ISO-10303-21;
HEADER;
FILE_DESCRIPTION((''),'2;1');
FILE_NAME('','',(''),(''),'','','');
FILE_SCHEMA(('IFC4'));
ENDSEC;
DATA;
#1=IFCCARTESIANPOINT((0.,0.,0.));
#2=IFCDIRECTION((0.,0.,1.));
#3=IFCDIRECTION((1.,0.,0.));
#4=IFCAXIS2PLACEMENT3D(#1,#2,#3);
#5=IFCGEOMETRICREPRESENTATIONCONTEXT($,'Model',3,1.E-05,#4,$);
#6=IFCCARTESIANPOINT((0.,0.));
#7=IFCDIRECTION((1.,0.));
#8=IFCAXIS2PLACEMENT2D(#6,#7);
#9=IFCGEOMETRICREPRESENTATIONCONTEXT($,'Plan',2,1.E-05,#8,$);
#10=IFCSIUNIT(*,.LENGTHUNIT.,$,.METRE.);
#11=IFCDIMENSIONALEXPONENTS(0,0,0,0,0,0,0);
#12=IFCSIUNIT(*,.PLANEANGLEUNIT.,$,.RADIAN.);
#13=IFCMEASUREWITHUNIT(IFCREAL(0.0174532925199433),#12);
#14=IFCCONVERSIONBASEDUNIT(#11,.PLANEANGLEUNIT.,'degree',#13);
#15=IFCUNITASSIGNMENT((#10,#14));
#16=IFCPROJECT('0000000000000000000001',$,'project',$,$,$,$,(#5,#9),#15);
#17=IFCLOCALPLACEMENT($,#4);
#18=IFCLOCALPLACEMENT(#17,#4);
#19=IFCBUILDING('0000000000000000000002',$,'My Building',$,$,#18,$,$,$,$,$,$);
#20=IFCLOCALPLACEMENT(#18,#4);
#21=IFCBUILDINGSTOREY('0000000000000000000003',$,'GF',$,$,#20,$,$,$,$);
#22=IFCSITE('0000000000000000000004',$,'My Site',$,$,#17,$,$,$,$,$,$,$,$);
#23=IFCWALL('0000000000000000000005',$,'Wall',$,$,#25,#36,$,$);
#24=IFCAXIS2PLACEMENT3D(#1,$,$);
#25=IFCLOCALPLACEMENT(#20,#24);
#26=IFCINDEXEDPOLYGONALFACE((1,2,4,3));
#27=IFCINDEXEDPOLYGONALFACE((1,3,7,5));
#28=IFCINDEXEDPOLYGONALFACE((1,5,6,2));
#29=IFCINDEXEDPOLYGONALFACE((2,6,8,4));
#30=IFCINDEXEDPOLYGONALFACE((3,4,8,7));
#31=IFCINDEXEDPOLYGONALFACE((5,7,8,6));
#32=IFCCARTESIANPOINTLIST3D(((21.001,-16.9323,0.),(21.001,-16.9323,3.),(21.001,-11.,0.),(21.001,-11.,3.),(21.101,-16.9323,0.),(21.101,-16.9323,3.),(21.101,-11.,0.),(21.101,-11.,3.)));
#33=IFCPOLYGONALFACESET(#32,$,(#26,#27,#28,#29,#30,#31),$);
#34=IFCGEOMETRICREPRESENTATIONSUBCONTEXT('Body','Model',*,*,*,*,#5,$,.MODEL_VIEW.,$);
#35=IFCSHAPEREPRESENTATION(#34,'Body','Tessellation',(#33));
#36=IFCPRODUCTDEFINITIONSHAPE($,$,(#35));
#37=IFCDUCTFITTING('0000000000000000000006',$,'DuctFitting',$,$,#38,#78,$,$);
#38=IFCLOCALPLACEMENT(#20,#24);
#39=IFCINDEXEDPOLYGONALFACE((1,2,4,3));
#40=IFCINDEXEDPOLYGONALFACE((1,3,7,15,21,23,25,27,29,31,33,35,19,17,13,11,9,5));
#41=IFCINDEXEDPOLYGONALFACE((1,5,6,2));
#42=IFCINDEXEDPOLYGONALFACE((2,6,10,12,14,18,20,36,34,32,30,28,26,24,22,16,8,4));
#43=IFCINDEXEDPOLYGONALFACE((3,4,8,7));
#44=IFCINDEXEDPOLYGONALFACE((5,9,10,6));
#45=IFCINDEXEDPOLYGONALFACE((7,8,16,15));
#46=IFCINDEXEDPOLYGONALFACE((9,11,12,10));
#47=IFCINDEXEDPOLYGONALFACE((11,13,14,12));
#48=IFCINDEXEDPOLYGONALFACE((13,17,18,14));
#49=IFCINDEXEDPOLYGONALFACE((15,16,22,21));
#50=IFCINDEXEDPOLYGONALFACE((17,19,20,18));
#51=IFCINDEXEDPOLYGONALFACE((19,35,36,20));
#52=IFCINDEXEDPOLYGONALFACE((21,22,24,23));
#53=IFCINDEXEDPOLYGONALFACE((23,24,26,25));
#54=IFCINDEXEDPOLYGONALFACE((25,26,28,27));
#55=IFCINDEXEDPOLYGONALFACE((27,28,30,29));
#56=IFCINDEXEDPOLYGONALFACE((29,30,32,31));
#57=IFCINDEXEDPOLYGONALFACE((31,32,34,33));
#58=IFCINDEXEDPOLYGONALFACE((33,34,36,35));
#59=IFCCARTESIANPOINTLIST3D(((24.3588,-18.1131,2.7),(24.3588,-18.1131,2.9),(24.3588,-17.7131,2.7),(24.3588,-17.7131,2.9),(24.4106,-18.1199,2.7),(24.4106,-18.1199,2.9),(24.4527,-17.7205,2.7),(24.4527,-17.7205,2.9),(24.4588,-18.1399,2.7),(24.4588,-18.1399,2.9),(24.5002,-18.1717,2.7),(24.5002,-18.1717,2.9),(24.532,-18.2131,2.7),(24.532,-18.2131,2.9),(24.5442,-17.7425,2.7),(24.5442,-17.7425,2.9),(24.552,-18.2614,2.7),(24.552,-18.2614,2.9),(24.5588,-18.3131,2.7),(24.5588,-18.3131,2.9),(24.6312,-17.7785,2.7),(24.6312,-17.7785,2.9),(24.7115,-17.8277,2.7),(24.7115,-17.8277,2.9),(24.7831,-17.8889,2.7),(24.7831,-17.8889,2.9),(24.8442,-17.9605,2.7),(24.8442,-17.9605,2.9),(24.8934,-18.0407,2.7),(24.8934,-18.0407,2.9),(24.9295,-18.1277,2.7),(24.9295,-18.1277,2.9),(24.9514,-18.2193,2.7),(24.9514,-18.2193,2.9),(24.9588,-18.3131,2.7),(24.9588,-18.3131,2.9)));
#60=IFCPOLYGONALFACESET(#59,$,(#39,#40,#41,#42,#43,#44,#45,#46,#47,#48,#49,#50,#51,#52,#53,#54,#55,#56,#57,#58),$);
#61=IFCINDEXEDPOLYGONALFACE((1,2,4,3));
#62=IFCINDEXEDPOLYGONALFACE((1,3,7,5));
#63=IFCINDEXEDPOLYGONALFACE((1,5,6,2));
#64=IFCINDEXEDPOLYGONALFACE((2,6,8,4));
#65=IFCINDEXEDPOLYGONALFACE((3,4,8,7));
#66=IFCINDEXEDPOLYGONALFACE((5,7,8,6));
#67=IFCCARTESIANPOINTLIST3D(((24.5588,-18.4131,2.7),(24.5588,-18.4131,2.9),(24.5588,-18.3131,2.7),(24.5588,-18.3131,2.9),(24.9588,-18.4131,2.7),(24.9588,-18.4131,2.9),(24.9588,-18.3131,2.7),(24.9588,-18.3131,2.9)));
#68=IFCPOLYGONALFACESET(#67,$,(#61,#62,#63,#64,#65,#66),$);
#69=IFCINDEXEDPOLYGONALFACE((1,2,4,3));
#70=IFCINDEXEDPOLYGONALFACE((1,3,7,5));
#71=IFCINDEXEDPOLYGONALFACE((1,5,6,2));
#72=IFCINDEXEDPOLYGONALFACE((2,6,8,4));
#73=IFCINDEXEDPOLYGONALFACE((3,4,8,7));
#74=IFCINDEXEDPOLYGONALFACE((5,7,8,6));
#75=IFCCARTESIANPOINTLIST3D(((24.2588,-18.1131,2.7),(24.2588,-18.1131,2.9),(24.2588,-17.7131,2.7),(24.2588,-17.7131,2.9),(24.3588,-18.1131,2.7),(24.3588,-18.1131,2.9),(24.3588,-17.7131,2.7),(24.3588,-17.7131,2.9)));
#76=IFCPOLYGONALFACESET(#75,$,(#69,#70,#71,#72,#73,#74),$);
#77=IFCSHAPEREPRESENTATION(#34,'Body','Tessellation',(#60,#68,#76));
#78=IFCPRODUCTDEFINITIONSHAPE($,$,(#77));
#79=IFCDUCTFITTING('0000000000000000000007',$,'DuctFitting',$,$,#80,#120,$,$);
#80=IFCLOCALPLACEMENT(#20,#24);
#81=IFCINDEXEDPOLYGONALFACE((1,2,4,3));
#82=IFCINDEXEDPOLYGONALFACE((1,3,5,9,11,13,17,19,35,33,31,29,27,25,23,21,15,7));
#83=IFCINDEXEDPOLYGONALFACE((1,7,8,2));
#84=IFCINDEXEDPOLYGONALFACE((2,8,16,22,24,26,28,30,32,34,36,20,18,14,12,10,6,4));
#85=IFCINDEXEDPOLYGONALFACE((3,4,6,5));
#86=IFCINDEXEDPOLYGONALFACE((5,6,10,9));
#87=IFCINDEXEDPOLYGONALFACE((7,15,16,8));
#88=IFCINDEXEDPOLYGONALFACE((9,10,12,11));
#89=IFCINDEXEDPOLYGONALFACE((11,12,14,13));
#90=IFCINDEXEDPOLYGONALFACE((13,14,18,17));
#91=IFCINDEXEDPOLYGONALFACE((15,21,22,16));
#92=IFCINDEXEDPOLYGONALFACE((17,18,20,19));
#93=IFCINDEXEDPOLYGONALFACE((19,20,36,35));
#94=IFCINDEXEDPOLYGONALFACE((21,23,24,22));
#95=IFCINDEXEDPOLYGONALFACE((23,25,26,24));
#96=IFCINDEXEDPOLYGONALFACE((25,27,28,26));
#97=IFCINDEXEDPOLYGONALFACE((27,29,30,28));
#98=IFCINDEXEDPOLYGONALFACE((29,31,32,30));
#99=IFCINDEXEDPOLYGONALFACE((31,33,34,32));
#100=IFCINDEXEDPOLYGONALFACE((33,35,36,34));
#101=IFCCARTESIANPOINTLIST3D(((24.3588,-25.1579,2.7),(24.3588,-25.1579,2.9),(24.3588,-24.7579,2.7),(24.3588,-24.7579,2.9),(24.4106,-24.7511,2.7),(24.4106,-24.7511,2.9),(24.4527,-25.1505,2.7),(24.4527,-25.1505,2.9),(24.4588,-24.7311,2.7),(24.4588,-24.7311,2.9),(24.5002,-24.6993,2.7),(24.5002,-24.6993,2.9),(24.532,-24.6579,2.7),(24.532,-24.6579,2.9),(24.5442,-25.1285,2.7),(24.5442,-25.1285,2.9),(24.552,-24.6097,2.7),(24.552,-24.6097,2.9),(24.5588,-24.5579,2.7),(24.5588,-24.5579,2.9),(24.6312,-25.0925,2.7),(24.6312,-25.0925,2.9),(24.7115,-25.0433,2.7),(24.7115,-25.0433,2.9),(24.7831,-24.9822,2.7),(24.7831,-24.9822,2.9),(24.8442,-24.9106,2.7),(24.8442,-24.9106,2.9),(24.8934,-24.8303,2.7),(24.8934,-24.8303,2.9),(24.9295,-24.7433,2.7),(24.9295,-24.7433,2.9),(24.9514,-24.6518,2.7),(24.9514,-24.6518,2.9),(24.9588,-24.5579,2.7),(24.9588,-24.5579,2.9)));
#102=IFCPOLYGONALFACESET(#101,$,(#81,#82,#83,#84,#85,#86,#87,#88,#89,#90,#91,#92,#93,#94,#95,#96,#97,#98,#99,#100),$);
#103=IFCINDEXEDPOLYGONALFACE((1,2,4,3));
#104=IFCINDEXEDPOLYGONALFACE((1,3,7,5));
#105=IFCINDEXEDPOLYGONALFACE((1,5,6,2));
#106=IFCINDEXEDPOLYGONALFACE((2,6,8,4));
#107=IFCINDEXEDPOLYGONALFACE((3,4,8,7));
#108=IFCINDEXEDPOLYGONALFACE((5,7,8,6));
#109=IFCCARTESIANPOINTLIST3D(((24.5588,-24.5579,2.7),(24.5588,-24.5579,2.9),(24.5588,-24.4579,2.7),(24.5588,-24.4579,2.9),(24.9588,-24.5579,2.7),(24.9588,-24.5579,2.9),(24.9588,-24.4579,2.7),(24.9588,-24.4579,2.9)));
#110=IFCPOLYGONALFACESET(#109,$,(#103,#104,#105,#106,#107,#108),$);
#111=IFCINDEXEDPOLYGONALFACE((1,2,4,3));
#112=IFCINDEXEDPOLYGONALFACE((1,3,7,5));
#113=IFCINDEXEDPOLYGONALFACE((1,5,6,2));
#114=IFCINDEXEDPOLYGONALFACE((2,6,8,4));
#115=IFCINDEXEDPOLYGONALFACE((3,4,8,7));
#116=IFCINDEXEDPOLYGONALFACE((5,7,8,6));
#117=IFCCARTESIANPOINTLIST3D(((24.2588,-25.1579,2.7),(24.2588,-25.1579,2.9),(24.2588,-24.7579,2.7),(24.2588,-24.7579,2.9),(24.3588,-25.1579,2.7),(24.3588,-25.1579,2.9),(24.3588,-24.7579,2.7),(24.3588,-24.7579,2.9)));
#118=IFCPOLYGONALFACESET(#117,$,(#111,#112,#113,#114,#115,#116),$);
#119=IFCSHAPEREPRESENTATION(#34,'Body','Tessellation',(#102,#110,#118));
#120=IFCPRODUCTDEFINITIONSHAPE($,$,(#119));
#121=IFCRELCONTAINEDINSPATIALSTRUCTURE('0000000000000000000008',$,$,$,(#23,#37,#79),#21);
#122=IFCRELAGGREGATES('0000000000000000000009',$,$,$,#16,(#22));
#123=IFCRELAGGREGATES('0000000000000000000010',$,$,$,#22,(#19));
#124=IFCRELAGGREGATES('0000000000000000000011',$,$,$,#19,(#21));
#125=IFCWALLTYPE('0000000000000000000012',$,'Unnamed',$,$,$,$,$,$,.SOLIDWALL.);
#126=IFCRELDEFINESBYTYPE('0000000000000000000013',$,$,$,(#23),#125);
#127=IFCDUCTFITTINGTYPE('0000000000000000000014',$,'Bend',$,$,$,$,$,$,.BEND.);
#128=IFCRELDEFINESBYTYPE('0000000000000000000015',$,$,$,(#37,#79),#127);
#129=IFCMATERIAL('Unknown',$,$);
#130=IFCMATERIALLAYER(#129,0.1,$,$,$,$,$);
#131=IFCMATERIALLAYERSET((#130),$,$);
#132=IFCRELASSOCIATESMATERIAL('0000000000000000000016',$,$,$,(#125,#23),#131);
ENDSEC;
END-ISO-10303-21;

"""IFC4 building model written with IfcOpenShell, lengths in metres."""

from ifc_helpers import new_model, entity, si_unit, converted_unit, frame, origin_with_axes, origin_2d_with_axis, place, context, subcontext, project, spatial, line, arc, indexed_curve, rectangle, outline, extrude, source, transform, mapped, material, layer, layer_set, layer_usage, type_object, type_shapes, element, save


model = new_model("IFC4")

# Units and contexts
model_context = context("Model", 3, precision=1e-05, world=origin_with_axes())
plan_context = context("Plan", 2, precision=1e-05, world=origin_2d_with_axis())
body_context_1 = subcontext(model_context, "Body", "Model", "MODEL_VIEW")
ifc_project = project(units=[si_unit("LENGTHUNIT", "METRE"), converted_unit("PLANEANGLEUNIT", "degree", entity("IfcReal", 0.0174532925199433), si_unit("PLANEANGLEUNIT", "RADIAN"), dimensions=[0, 0, 0, 0, 0, 0, 0])], contexts=[model_context, plan_context])

# Site, building, storey
site_placement = place(None, origin_with_axes())
site = spatial("IfcSite", under=ifc_project, at=site_placement, Name="My Site")
building_placement = place(site_placement, origin_with_axes())
building = spatial("IfcBuilding", under=site, at=building_placement, Name="My Building")
storey_placement = place(building_placement, origin_with_axes())
storey = spatial("IfcBuildingStorey", under=building, at=storey_placement, Name="GF")

# Shared definitions
ifc_material = material(Name="Unknown")
ifc_layer = layer(ifc_material, 0.1)
ifc_layer_set = layer_set([ifc_layer])
wall_type = type_object("IfcWallType", Name="Unnamed", PredefinedType="SOLIDWALL", material=ifc_layer_set)

# Wall
ifc_layer_usage_1 = layer_usage(ifc_layer_set, "AXIS2", "POSITIVE", 0.0)
wall_1_placement = place(storey_placement, frame((21.101, -16.9323, 0.0), z_axis=(0.0, 0.0, 1.0), x_axis=(0.0, 1.0, 0.0)))
element("IfcWall", 1, at=wall_1_placement, inside=storey, type_object=wall_type, material=ifc_layer_usage_1, Name="Wall", context=body_context_1, shape_type="SweptSolid", body=[
    extrude(outline(indexed_curve([(0.0, 0.0), (0.0, 0.1), (5.9323, 0.1), (5.9323, 0.0)], segments=[line(1, 2, 3, 4, 1)])), origin_with_axes(), (0.0, 0.0, 1.0), 3.0),
])

# Duct fittings
duct_fitting_type = type_object("IfcDuctFittingType", Name="Bend", PredefinedType="BEND")
shared_shape_1 = source(origin_with_axes(), body_context_1, "Body", "SweptSolid", [
    extrude(outline(indexed_curve([(-0.2, 0.0), (-0.2586, -0.1414), (-0.4, -0.2), (-0.4, -0.6), (0.0243, -0.4243), (0.2, 0.0)], segments=[arc(1, 2, 3), line(3, 4), arc(4, 5, 6), line(6, 1)])), frame((0.0, -0.1, -0.1), z_axis=(0.0, -1.0, 0.0), x_axis=(1.0, 0.0, 0.0)), (0.0, 0.0, -1.0), 0.2),
    extrude(rectangle(XDim=0.4, YDim=0.2), origin_with_axes(), (0.0, 0.0, -1.0), 0.1),
    extrude(rectangle(XDim=0.4, YDim=0.2), frame((-0.4, 0.0, -0.5), z_axis=(-1.0, 0.0, 0.0), x_axis=(0.0, 0.0, -1.0)), (0.0, 0.0, 1.0), 0.1),
])
type_shapes(duct_fitting_type, [shared_shape_1])
for number, where, z_axis, x_axis, name in (
    (2, (24.7588, -18.4131, 2.8), (0.0, -1.0, 0.0), (1.0, 0.0, 0.0), "DuctFitting"),
    (3, (24.7588, -24.4579, 2.8), (0.0, 1.0, 0.0), (1.0, 0.0, 0.0), "DuctFitting"),
):
    element("IfcDuctFitting", number, at=place(storey_placement, frame(where, z_axis=z_axis, x_axis=x_axis)), inside=storey, type_object=duct_fitting_type, Name=name, context=body_context_1, shape_type="MappedRepresentation", body=[
        mapped(shared_shape_1, transform((0.0, 0.0, 0.0), x_axis=(1.0, 0.0, 0.0), y_axis=(0.0, 1.0, 0.0), z_axis=(0.0, 0.0, 1.0), scale=1.0)),
    ])

save(model, "model.ifc")
